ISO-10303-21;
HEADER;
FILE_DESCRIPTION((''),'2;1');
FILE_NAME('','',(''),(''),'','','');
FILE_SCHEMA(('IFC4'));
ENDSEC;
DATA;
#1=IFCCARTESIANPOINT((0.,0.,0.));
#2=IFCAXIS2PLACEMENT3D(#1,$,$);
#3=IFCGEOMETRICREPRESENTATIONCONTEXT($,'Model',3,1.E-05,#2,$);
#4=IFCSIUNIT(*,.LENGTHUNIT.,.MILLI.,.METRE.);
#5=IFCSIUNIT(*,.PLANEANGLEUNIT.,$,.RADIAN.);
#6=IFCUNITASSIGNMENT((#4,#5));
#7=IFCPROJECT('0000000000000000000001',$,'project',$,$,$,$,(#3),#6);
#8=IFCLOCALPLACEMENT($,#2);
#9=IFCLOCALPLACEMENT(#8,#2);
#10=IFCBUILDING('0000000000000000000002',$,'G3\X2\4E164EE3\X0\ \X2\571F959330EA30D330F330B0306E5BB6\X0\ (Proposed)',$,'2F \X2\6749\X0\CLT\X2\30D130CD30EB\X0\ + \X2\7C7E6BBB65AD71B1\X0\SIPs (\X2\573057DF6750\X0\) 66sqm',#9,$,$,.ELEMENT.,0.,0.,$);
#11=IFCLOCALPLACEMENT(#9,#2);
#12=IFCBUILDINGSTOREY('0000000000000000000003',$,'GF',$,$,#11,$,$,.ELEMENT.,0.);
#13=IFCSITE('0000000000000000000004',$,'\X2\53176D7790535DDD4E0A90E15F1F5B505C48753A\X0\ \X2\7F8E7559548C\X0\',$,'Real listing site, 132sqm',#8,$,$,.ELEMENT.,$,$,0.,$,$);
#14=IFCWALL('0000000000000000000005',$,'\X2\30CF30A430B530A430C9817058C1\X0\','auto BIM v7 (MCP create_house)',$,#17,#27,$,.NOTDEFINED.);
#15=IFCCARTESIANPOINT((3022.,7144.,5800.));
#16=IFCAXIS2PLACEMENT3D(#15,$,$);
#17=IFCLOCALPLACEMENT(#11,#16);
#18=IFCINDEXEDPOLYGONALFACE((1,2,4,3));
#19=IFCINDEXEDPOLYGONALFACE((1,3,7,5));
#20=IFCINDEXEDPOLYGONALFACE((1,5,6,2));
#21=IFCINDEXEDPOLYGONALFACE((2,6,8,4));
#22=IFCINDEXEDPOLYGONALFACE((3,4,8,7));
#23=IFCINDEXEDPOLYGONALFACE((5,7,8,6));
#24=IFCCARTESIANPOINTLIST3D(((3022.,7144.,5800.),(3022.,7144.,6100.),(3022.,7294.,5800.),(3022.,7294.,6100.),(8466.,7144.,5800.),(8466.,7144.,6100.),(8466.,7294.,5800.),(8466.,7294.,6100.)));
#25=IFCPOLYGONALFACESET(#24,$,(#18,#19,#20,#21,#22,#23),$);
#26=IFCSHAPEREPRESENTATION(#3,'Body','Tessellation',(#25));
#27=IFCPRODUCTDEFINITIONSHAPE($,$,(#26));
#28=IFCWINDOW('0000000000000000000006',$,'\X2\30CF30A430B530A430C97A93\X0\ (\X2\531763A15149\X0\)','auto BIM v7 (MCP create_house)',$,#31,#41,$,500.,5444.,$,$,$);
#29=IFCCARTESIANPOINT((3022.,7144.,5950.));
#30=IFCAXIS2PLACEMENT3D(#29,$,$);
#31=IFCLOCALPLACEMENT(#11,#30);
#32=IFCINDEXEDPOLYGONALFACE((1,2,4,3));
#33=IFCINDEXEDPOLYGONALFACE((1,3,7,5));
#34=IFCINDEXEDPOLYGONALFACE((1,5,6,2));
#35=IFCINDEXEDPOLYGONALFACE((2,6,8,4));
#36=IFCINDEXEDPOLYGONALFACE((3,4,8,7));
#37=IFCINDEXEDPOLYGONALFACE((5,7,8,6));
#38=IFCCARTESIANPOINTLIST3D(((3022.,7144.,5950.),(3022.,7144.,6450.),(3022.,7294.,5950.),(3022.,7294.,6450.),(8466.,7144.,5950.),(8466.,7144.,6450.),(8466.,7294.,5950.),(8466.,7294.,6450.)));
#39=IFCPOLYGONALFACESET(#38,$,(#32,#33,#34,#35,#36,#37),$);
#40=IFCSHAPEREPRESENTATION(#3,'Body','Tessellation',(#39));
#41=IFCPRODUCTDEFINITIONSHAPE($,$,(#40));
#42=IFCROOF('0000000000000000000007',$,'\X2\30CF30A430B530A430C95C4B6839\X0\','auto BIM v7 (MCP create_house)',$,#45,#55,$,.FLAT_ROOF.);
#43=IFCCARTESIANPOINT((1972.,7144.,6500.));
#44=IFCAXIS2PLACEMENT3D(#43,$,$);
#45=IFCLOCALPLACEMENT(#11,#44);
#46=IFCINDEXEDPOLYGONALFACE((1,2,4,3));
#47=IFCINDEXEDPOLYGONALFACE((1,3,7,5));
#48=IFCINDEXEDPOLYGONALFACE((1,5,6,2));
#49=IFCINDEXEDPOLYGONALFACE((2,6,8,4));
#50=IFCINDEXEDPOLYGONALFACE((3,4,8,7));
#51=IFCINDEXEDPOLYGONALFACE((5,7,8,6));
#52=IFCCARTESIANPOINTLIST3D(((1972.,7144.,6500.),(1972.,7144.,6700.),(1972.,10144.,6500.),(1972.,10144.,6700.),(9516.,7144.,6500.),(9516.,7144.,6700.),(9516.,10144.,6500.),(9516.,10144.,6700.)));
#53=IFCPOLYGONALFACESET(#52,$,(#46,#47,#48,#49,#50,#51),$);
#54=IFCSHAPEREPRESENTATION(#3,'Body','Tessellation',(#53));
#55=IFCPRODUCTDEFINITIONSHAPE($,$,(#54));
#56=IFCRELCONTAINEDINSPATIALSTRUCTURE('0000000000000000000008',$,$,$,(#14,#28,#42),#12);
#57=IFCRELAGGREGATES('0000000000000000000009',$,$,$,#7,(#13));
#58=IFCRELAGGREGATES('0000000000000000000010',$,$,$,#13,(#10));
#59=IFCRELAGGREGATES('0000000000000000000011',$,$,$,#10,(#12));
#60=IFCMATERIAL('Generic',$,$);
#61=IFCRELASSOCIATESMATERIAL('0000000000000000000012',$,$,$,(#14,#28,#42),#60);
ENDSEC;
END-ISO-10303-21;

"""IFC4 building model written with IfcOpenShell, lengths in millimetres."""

from ifc_helpers import new_model, si_unit, frame, frame_2d, origin, place, context, project, spatial, rectangle, extrude, material, element, fill, save


model = new_model("IFC4")

# Units and contexts
model_context = context("Model", 3, precision=1e-05, world=origin())
ifc_project = project(units=[si_unit("LENGTHUNIT", "METRE", prefix="MILLI"), si_unit("PLANEANGLEUNIT", "RADIAN")], contexts=[model_context])

# Site, building, storey
site_placement = place(None, origin())
site = spatial("IfcSite", under=ifc_project, at=site_placement, Name="北海道川上郡弟子屈町 美留和", ObjectType="Real listing site, 132sqm", CompositionType="ELEMENT", RefElevation=0.0)
building_placement = place(site_placement, origin())
building = spatial("IfcBuilding", under=site, at=building_placement, Name="G3世代 土間リビングの家 (Proposed)", ObjectType="2F 杉CLTパネル + 籾殻断熱SIPs (地域材) 66sqm", CompositionType="ELEMENT", ElevationOfRefHeight=0.0, ElevationOfTerrain=0.0)
storey_placement = place(building_placement, origin())
storey = spatial("IfcBuildingStorey", under=building, at=storey_placement, Name="GF", CompositionType="ELEMENT", Elevation=0.0)

# Shared definitions
ifc_material = material(Name="Generic")

# Wall, opening, window
wall_1_placement = place(storey_placement, frame((3022.0, 7144.0, 5800.0)))
wall_1 = element("IfcWall", 1, at=wall_1_placement, inside=storey, material=ifc_material, Name="ハイサイド腰壁", Description="auto BIM v7 (MCP create_house)", PredefinedType="NOTDEFINED", context=model_context, shape_type="SweptSolid", body=[
    extrude(rectangle(XDim=5444.0, YDim=150.0, at=frame_2d((2722.0, 75.0))), frame((3022.0, 7144.0, 5800.0)), (0.0, 0.0, 1.0), 700.0),
])
opening_1_placement = place(storey_placement, frame((3022.0, 7144.0, 5950.0)))
opening_1 = element("IfcOpeningElement", 2, at=opening_1_placement, cuts=wall_1, PredefinedType="NOTDEFINED", context=model_context, shape_type="SweptSolid", body=[
    extrude(rectangle(XDim=5444.0, YDim=150.0, at=frame_2d((2722.0, 75.0))), frame((3022.0, 7144.0, 5950.0)), (0.0, 0.0, 1.0), 500.0),
])
window_1_placement = place(storey_placement, frame((3022.0, 7144.0, 5950.0)))
window_1 = element("IfcWindow", 3, at=window_1_placement, inside=storey, material=ifc_material, Name="ハイサイド窓 (北採光)", Description="auto BIM v7 (MCP create_house)", OverallHeight=500.0, OverallWidth=5444.0, context=model_context, shape_type="SweptSolid", body=[
    extrude(rectangle(XDim=5444.0, YDim=150.0, at=frame_2d((2722.0, 75.0))), frame((3022.0, 7144.0, 5950.0)), (0.0, 0.0, 1.0), 500.0),
])
fill(opening_1, window_1)

# Roof
roof_placement = place(storey_placement, frame((1972.0, 7144.0, 6500.0)))
element("IfcRoof", 4, at=roof_placement, inside=storey, material=ifc_material, Name="ハイサイド屋根", Description="auto BIM v7 (MCP create_house)", PredefinedType="FLAT_ROOF", context=model_context, shape_type="SweptSolid", body=[
    extrude(rectangle(XDim=7544.0, YDim=3000.0, at=frame_2d((3772.0, 1500.0))), frame((1972.0, 7144.0, 6500.0)), (0.0, 0.0, 1.0), 200.0),
])

save(model, "model.ifc")
